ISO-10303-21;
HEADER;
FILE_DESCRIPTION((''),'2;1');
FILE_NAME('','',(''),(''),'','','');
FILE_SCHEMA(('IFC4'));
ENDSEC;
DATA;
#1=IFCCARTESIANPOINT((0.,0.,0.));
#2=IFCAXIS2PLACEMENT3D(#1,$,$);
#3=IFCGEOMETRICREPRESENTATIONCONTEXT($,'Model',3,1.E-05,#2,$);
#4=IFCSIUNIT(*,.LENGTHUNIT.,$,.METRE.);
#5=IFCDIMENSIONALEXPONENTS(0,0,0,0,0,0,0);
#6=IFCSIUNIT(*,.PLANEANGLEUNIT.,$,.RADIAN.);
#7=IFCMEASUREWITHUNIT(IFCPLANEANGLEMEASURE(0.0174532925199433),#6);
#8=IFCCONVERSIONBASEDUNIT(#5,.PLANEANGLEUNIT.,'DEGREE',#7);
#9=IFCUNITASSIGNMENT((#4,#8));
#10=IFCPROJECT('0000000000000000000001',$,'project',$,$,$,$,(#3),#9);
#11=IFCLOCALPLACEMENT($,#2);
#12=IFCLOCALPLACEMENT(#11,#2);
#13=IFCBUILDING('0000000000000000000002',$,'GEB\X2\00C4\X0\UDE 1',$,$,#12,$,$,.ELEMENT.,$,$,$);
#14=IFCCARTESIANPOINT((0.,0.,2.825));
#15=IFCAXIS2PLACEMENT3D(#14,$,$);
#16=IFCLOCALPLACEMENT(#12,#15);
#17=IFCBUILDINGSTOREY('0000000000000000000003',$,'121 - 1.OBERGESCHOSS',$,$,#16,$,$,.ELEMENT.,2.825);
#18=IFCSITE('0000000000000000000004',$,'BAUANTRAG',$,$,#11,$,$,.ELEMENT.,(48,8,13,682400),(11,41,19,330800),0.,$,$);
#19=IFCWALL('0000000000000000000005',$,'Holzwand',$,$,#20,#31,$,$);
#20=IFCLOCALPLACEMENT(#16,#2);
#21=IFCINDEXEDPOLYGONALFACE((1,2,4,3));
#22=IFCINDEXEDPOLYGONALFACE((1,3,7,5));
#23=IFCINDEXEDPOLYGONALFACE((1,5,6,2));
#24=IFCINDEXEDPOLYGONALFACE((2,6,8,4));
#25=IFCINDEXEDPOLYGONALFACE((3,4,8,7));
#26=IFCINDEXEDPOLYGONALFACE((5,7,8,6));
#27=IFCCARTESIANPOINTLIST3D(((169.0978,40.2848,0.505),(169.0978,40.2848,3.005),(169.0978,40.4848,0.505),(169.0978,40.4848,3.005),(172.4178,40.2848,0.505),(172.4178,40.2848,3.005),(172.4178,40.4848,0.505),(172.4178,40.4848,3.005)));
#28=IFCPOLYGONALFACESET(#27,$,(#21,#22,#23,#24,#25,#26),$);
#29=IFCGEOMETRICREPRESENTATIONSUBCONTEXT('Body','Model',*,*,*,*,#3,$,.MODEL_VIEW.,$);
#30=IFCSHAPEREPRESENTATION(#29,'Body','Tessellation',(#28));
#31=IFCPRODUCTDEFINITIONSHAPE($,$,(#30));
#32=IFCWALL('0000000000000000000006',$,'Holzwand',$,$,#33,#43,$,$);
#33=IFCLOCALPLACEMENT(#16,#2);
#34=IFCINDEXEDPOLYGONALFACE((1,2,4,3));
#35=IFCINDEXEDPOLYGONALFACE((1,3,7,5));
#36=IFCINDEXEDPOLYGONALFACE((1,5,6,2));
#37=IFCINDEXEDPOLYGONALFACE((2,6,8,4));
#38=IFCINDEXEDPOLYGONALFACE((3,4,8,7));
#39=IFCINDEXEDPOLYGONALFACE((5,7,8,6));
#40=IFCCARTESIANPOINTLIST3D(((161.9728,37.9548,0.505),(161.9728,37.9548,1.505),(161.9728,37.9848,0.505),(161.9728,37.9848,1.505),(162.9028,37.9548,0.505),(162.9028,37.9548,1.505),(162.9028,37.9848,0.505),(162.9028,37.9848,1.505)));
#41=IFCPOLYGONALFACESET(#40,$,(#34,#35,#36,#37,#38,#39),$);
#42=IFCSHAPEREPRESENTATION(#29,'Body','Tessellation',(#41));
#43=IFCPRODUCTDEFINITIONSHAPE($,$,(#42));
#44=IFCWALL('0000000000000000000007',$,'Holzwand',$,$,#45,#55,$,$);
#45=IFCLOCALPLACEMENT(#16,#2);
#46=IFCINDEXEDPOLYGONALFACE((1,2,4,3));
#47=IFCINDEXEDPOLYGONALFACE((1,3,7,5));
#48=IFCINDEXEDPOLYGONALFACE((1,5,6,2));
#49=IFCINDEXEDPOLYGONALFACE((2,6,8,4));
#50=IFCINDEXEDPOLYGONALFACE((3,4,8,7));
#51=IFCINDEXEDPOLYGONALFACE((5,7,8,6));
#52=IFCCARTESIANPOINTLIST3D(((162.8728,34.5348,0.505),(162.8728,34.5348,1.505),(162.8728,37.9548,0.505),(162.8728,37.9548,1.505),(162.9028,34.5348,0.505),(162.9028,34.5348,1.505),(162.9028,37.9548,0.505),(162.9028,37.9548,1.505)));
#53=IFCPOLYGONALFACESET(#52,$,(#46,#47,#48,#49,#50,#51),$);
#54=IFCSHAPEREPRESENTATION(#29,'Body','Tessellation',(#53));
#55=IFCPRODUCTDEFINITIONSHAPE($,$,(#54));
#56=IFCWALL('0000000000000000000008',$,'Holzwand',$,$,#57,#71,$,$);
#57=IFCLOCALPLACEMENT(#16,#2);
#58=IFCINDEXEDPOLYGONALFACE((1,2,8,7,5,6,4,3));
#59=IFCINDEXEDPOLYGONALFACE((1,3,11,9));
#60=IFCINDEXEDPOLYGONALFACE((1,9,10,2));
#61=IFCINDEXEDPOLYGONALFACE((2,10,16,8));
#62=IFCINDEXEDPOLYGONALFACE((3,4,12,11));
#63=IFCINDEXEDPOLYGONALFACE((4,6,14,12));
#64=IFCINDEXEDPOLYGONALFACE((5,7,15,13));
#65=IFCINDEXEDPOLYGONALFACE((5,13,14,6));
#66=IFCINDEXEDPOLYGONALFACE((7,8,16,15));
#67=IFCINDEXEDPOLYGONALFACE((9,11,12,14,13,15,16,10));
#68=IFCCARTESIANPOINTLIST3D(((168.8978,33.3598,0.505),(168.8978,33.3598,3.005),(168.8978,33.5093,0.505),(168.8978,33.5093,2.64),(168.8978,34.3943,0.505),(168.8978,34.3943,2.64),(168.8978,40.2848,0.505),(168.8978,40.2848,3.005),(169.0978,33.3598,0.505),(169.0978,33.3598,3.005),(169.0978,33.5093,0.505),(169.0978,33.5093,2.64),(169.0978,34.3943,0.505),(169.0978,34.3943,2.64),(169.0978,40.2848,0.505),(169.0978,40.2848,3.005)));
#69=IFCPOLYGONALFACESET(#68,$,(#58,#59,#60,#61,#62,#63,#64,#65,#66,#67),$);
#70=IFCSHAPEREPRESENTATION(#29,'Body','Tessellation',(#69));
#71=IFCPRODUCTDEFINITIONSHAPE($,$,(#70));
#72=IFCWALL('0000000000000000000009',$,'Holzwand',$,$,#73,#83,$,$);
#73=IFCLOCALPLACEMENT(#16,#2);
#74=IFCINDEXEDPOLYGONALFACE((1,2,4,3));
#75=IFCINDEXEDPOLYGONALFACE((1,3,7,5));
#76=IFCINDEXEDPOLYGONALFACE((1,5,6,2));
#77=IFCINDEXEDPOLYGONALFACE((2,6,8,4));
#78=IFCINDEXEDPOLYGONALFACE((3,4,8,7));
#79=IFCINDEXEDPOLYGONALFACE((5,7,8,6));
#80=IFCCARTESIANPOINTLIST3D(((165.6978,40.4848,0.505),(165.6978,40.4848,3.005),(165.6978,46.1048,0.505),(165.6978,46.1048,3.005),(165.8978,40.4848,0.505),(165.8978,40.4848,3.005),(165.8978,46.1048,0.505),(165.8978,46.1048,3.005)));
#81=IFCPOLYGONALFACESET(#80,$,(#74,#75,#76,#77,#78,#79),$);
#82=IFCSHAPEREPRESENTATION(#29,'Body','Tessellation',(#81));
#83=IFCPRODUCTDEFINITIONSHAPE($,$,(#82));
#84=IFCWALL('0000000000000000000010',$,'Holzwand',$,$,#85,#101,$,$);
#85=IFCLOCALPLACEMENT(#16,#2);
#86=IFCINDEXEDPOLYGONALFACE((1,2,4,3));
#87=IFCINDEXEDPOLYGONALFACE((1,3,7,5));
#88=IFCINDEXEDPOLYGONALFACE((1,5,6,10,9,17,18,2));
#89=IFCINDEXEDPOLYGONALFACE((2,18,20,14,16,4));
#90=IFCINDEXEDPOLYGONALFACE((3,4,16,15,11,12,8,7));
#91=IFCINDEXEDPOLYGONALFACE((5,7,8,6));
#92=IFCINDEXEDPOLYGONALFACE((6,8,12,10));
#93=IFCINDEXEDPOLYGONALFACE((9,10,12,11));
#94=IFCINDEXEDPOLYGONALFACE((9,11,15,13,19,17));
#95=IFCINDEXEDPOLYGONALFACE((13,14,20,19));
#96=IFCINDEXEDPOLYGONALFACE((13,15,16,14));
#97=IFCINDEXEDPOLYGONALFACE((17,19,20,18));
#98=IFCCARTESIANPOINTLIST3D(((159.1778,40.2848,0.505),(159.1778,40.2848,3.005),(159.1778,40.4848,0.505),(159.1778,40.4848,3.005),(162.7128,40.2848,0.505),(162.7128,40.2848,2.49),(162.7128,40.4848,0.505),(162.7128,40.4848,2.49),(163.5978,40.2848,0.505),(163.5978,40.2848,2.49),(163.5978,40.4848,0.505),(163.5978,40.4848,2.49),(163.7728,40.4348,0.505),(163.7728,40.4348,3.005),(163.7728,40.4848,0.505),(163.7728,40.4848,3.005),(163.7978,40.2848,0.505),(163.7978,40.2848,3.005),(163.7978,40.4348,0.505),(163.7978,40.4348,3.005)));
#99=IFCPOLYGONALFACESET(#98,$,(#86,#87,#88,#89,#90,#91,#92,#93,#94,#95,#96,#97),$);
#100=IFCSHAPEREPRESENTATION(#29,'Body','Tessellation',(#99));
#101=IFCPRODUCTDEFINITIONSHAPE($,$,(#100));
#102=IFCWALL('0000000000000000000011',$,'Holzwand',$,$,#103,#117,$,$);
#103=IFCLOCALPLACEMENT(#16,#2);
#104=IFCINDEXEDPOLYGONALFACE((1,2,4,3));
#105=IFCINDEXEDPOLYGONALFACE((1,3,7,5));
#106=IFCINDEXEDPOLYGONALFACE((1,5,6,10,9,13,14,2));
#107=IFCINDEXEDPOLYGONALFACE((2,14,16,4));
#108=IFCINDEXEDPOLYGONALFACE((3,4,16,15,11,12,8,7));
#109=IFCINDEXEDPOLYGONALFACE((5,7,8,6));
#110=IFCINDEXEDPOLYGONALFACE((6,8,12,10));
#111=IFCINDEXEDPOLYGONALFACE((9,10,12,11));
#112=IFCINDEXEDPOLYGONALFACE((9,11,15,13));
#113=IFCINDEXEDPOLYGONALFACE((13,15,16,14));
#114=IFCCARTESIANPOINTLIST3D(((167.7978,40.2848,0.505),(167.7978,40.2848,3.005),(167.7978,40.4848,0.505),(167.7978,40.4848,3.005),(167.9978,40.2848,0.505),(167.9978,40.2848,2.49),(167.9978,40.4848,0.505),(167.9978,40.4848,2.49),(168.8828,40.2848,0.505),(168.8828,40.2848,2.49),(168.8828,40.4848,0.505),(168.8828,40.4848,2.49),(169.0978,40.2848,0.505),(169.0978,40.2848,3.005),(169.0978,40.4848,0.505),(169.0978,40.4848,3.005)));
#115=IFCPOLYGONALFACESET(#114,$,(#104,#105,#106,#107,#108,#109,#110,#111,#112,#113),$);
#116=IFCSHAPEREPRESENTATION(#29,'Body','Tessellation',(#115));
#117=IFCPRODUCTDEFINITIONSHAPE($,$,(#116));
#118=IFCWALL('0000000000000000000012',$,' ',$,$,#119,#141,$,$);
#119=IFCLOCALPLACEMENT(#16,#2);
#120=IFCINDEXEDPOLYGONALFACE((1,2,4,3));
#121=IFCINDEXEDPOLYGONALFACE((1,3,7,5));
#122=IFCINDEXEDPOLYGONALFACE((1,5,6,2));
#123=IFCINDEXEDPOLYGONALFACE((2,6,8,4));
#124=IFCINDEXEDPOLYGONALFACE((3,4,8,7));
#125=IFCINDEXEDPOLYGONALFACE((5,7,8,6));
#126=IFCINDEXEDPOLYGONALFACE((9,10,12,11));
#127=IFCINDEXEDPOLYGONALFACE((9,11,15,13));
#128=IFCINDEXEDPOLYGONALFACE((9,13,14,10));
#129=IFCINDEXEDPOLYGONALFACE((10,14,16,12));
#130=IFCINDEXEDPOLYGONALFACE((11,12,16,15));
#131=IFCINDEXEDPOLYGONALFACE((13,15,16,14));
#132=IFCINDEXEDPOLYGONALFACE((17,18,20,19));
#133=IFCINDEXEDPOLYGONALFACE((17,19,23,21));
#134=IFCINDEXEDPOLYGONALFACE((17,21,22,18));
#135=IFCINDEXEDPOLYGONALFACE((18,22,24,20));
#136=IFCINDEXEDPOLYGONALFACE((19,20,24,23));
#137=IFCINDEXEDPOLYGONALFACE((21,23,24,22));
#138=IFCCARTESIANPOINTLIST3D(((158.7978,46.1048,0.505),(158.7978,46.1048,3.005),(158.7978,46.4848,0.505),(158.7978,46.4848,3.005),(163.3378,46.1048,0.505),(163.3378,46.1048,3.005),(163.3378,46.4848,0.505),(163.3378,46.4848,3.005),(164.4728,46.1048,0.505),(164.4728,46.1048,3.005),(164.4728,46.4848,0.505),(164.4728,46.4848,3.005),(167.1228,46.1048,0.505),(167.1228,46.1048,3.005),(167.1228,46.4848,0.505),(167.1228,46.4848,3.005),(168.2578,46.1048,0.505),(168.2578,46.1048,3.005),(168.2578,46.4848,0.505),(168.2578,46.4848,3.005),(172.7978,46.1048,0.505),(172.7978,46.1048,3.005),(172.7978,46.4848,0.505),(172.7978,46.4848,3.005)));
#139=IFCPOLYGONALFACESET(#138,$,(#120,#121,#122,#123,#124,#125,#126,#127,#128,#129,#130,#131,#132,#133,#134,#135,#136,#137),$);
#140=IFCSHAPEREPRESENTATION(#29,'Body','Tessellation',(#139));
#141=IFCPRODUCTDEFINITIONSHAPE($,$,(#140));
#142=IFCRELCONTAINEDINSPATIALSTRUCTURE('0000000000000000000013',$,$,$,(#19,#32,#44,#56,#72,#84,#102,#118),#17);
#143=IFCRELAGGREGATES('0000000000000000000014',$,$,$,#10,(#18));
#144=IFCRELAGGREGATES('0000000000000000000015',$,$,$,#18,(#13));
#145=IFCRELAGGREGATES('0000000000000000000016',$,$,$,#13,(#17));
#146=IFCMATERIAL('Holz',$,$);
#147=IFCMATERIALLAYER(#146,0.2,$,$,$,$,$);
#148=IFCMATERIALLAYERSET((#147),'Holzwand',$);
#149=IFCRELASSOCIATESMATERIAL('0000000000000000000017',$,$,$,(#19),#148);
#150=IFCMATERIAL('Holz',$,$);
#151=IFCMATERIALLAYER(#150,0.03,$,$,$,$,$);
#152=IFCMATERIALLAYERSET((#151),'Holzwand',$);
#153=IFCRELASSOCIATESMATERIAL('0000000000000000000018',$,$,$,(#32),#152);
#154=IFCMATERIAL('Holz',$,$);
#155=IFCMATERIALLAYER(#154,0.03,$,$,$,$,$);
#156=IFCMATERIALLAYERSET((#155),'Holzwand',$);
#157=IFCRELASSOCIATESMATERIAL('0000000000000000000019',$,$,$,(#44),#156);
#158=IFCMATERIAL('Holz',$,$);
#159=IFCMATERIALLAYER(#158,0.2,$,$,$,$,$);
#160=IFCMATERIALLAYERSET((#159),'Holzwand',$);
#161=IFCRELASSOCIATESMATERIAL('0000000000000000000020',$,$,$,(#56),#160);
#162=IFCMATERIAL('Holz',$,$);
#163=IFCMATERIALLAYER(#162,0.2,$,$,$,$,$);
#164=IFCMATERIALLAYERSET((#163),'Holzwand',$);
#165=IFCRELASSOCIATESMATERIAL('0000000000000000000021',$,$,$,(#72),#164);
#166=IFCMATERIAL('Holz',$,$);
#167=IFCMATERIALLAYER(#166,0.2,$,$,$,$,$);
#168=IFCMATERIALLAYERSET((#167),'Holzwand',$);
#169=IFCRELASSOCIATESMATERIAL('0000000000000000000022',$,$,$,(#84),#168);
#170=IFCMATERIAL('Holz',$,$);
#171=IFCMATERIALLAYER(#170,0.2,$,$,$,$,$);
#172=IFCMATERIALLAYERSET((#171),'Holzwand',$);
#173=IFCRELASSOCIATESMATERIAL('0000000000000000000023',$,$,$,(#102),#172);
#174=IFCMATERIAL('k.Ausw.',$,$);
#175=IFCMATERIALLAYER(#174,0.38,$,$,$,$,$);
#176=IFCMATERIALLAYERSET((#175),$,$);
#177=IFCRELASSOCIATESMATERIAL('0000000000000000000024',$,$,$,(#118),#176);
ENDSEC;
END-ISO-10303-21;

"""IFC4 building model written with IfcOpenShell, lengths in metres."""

from ifc_helpers import new_model, entity, si_unit, converted_unit, frame, frame_2d, origin, origin_with_axes, place, context, subcontext, project, spatial, polyline, rectangle, outline, extrude, material, layer, layer_set, layer_usage, element, save


model = new_model("IFC4")

# Units and contexts
model_context = context("Model", 3, precision=1e-05, world=origin())
body_context = subcontext(model_context, "Body", "Model", "MODEL_VIEW")
ifc_project = project(units=[si_unit("LENGTHUNIT", "METRE"), converted_unit("PLANEANGLEUNIT", "DEGREE", entity("IfcPlaneAngleMeasure", 0.0174532925199433), si_unit("PLANEANGLEUNIT", "RADIAN"), dimensions=[0, 0, 0, 0, 0, 0, 0])], contexts=[model_context])

# Site, building, storey
site_placement = place(None, origin())
site = spatial("IfcSite", under=ifc_project, at=site_placement, Name="BAUANTRAG", CompositionType="ELEMENT", RefLatitude=(48, 8, 13, 682400), RefLongitude=(11, 41, 19, 330800), RefElevation=0.0)
building_placement = place(site_placement, origin())
building = spatial("IfcBuilding", under=site, at=building_placement, Name="GEBÄUDE 1", CompositionType="ELEMENT")
storey_placement = place(building_placement, frame((0.0, 0.0, 2.825)))
storey = spatial("IfcBuildingStorey", under=building, at=storey_placement, Name="121 - 1.OBERGESCHOSS", CompositionType="ELEMENT", Elevation=2.825)

# Walls
ifc_material_1 = material(Name="Holz")
ifc_layer_1 = layer(ifc_material_1, 0.2)
ifc_layer_set_1 = layer_set([ifc_layer_1], Name="Holzwand")
ifc_layer_usage_1 = layer_usage(ifc_layer_set_1, "AXIS2", "POSITIVE", -0.1)
wall_1_placement = place(storey_placement, frame((172.4178, 40.4848, 0.505), z_axis=(0.0, 0.0, 1.0), x_axis=(-1.0, 0.0, 0.0)))
element("IfcWall", 1, at=wall_1_placement, inside=storey, material=ifc_layer_usage_1, Name="Holzwand", context=body_context, shape_type="SweptSolid", body=[
    extrude(rectangle(XDim=3.32, YDim=0.2, at=frame_2d((1.66, 0.1), x_axis=(1.0, 0.0))), origin_with_axes(), (0.0, 0.0, 1.0), 2.5),
])
ifc_material_2 = material(Name="Holz")
ifc_layer_2 = layer(ifc_material_2, 0.03)
ifc_layer_set_2 = layer_set([ifc_layer_2], Name="Holzwand")
ifc_layer_usage_2 = layer_usage(ifc_layer_set_2, "AXIS2", "POSITIVE", 0.0)
wall_2_placement = place(storey_placement, frame((161.9728, 37.9548, 0.505), z_axis=(0.0, 0.0, 1.0), x_axis=(1.0, 0.0, 0.0)))
element("IfcWall", 2, at=wall_2_placement, inside=storey, material=ifc_layer_usage_2, Name="Holzwand", context=body_context, shape_type="SweptSolid", body=[
    extrude(rectangle(XDim=0.93, YDim=0.03, at=frame_2d((0.465, 0.015), x_axis=(1.0, 0.0))), origin_with_axes(), (0.0, 0.0, 1.0), 1.0),
])
ifc_material_3 = material(Name="Holz")
ifc_layer_3 = layer(ifc_material_3, 0.03)
ifc_layer_set_3 = layer_set([ifc_layer_3], Name="Holzwand")
ifc_layer_usage_3 = layer_usage(ifc_layer_set_3, "AXIS2", "POSITIVE", 0.0)
wall_3_placement = place(storey_placement, frame((162.8728, 37.9548, 0.505), z_axis=(0.0, 0.0, 1.0), x_axis=(0.0, -1.0, 0.0)))
element("IfcWall", 3, at=wall_3_placement, inside=storey, material=ifc_layer_usage_3, Name="Holzwand", context=body_context, shape_type="SweptSolid", body=[
    extrude(rectangle(XDim=3.42, YDim=0.03, at=frame_2d((1.71, 0.015), x_axis=(1.0, 0.0))), origin_with_axes(), (0.0, 0.0, 1.0), 1.0),
])

# Wall, opening
ifc_material_4 = material(Name="Holz")
ifc_layer_4 = layer(ifc_material_4, 0.2)
ifc_layer_set_4 = layer_set([ifc_layer_4], Name="Holzwand")
ifc_layer_usage_4 = layer_usage(ifc_layer_set_4, "AXIS2", "POSITIVE", 0.0)
wall_4_placement = place(storey_placement, frame((168.8978, 40.2848, 0.505), z_axis=(0.0, 0.0, 1.0), x_axis=(0.0, -1.0, 0.0)))
wall_4 = element("IfcWall", 4, at=wall_4_placement, inside=storey, material=ifc_layer_usage_4, Name="Holzwand", context=body_context, shape_type="SweptSolid", body=[
    extrude(rectangle(XDim=6.925, YDim=0.2, at=frame_2d((3.4625, 0.1), x_axis=(1.0, 0.0))), origin_with_axes(), (0.0, 0.0, 1.0), 2.5),
])
opening_1_placement = place(wall_4_placement, frame((6.7755, 0.2, -0.15), z_axis=(0.0, -1.0, 0.0), x_axis=(0.0, 0.0, 1.0)))
element("IfcOpeningElement", 5, at=opening_1_placement, cuts=wall_4, ObjectType="Opening", context=body_context, shape_type="SweptSolid", body=[
    extrude(outline(polyline([(0.0, 0.885), (2.285, 0.885), (2.285, 0.0), (0.0, 0.0), (0.0, 0.885)])), origin_with_axes(), (0.0, 0.0, 1.0), 0.2),
])

# Wall
ifc_material_5 = material(Name="Holz")
ifc_layer_5 = layer(ifc_material_5, 0.2)
ifc_layer_set_5 = layer_set([ifc_layer_5], Name="Holzwand")
ifc_layer_usage_5 = layer_usage(ifc_layer_set_5, "AXIS2", "POSITIVE", 0.0)
wall_5_placement = place(storey_placement, frame((165.6978, 46.1048, 0.505), z_axis=(0.0, 0.0, 1.0), x_axis=(0.0, -1.0, 0.0)))
element("IfcWall", 6, at=wall_5_placement, inside=storey, material=ifc_layer_usage_5, Name="Holzwand", context=body_context, shape_type="SweptSolid", body=[
    extrude(rectangle(XDim=5.62, YDim=0.2, at=frame_2d((2.81, 0.1), x_axis=(1.0, 0.0))), origin_with_axes(), (0.0, 0.0, 1.0), 2.5),
])

# Walls, openings
ifc_material_6 = material(Name="Holz")
ifc_layer_6 = layer(ifc_material_6, 0.2)
ifc_layer_set_6 = layer_set([ifc_layer_6], Name="Holzwand")
ifc_layer_usage_6 = layer_usage(ifc_layer_set_6, "AXIS2", "POSITIVE", 0.0)
wall_6_placement = place(storey_placement, frame((163.7728, 40.4848, 0.505), z_axis=(0.0, 0.0, 1.0), x_axis=(-1.0, 0.0, 0.0)))
wall_6 = element("IfcWall", 7, at=wall_6_placement, inside=storey, material=ifc_layer_usage_6, Name="Holzwand", context=body_context, shape_type="SweptSolid", body=[
    extrude(outline(polyline([(-4.595, -0.2), (0.0, -0.2), (0.0, 0.0), (-4.62, 0.0), (-4.62, -0.15), (-4.595, -0.15), (-4.595, -0.2)])), frame((4.595, 0.2, 0.0), z_axis=(0.0, 0.0, 1.0), x_axis=(1.0, 0.0, 0.0)), (0.0, 0.0, 1.0), 2.5),
])
opening_2_placement = place(wall_6_placement, frame((1.06, 0.2, -0.15), z_axis=(0.0, -1.0, 0.0), x_axis=(0.0, 0.0, 1.0)))
element("IfcOpeningElement", 8, at=opening_2_placement, cuts=wall_6, ObjectType="Opening", context=body_context, shape_type="SweptSolid", body=[
    extrude(outline(polyline([(0.0, 0.885), (2.135, 0.885), (2.135, 0.0), (0.0, 0.0), (0.0, 0.885)])), origin_with_axes(), (0.0, 0.0, 1.0), 0.2),
])
ifc_material_7 = material(Name="Holz")
ifc_layer_7 = layer(ifc_material_7, 0.2)
ifc_layer_set_7 = layer_set([ifc_layer_7], Name="Holzwand")
ifc_layer_usage_7 = layer_usage(ifc_layer_set_7, "AXIS2", "POSITIVE", 0.0)
wall_7_placement = place(storey_placement, frame((169.0978, 40.4848, 0.505), z_axis=(0.0, 0.0, 1.0), x_axis=(-1.0, 0.0, 0.0)))
wall_7 = element("IfcWall", 9, at=wall_7_placement, inside=storey, material=ifc_layer_usage_7, Name="Holzwand", context=body_context, shape_type="SweptSolid", body=[
    extrude(rectangle(XDim=1.3, YDim=0.2, at=frame_2d((0.65, 0.1), x_axis=(1.0, 0.0))), origin_with_axes(), (0.0, 0.0, 1.0), 2.5),
])
opening_3_placement = place(wall_7_placement, frame((1.1, 0.2, -0.15), z_axis=(0.0, -1.0, 0.0), x_axis=(0.0, 0.0, 1.0)))
element("IfcOpeningElement", 10, at=opening_3_placement, cuts=wall_7, ObjectType="Opening", context=body_context, shape_type="SweptSolid", body=[
    extrude(outline(polyline([(0.0, 0.885), (2.135, 0.885), (2.135, 0.0), (0.0, 0.0), (0.0, 0.885)])), origin_with_axes(), (0.0, 0.0, 1.0), 0.2),
])

# Wall, openings
ifc_material_8 = material(Name="k.Ausw.")
ifc_layer_8 = layer(ifc_material_8, 0.38)
ifc_layer_set_8 = layer_set([ifc_layer_8])
ifc_layer_usage_8 = layer_usage(ifc_layer_set_8, "AXIS2", "POSITIVE", 0.0)
wall_8_placement = place(storey_placement, frame((172.7978, 46.4848, 0.505), z_axis=(0.0, 0.0, 1.0), x_axis=(-1.0, 0.0, 0.0)))
wall_8 = element("IfcWall", 11, at=wall_8_placement, inside=storey, material=ifc_layer_usage_8, Name=" ", context=body_context, shape_type="SweptSolid", body=[
    extrude(rectangle(XDim=14.0, YDim=0.38, at=frame_2d((7.0, 0.19), x_axis=(1.0, 0.0))), origin_with_axes(), (0.0, 0.0, 1.0), 2.5),
])
opening_4_placement = place(wall_8_placement, frame((9.46, 0.38, 0.0), z_axis=(0.0, -1.0, 0.0), x_axis=(0.0, 0.0, 1.0)))
element("IfcOpeningElement", 12, at=opening_4_placement, cuts=wall_8, ObjectType="Opening", context=body_context, shape_type="SweptSolid", body=[
    extrude(outline(polyline([(0.0, 1.135), (2.5, 1.135), (2.5, 0.0), (0.0, 0.0), (0.0, 1.135)])), origin_with_axes(), (0.0, 0.0, 1.0), 0.38),
])
opening_5_placement = place(wall_8_placement, frame((5.675, 0.38, 0.0), z_axis=(0.0, -1.0, 0.0), x_axis=(0.0, 0.0, 1.0)))
element("IfcOpeningElement", 13, at=opening_5_placement, cuts=wall_8, ObjectType="Opening", context=body_context, shape_type="SweptSolid", body=[
    extrude(outline(polyline([(0.0, 1.135), (2.5, 1.135), (2.5, 0.0), (0.0, 0.0), (0.0, 1.135)])), origin_with_axes(), (0.0, 0.0, 1.0), 0.38),
])

save(model, "model.ifc")
